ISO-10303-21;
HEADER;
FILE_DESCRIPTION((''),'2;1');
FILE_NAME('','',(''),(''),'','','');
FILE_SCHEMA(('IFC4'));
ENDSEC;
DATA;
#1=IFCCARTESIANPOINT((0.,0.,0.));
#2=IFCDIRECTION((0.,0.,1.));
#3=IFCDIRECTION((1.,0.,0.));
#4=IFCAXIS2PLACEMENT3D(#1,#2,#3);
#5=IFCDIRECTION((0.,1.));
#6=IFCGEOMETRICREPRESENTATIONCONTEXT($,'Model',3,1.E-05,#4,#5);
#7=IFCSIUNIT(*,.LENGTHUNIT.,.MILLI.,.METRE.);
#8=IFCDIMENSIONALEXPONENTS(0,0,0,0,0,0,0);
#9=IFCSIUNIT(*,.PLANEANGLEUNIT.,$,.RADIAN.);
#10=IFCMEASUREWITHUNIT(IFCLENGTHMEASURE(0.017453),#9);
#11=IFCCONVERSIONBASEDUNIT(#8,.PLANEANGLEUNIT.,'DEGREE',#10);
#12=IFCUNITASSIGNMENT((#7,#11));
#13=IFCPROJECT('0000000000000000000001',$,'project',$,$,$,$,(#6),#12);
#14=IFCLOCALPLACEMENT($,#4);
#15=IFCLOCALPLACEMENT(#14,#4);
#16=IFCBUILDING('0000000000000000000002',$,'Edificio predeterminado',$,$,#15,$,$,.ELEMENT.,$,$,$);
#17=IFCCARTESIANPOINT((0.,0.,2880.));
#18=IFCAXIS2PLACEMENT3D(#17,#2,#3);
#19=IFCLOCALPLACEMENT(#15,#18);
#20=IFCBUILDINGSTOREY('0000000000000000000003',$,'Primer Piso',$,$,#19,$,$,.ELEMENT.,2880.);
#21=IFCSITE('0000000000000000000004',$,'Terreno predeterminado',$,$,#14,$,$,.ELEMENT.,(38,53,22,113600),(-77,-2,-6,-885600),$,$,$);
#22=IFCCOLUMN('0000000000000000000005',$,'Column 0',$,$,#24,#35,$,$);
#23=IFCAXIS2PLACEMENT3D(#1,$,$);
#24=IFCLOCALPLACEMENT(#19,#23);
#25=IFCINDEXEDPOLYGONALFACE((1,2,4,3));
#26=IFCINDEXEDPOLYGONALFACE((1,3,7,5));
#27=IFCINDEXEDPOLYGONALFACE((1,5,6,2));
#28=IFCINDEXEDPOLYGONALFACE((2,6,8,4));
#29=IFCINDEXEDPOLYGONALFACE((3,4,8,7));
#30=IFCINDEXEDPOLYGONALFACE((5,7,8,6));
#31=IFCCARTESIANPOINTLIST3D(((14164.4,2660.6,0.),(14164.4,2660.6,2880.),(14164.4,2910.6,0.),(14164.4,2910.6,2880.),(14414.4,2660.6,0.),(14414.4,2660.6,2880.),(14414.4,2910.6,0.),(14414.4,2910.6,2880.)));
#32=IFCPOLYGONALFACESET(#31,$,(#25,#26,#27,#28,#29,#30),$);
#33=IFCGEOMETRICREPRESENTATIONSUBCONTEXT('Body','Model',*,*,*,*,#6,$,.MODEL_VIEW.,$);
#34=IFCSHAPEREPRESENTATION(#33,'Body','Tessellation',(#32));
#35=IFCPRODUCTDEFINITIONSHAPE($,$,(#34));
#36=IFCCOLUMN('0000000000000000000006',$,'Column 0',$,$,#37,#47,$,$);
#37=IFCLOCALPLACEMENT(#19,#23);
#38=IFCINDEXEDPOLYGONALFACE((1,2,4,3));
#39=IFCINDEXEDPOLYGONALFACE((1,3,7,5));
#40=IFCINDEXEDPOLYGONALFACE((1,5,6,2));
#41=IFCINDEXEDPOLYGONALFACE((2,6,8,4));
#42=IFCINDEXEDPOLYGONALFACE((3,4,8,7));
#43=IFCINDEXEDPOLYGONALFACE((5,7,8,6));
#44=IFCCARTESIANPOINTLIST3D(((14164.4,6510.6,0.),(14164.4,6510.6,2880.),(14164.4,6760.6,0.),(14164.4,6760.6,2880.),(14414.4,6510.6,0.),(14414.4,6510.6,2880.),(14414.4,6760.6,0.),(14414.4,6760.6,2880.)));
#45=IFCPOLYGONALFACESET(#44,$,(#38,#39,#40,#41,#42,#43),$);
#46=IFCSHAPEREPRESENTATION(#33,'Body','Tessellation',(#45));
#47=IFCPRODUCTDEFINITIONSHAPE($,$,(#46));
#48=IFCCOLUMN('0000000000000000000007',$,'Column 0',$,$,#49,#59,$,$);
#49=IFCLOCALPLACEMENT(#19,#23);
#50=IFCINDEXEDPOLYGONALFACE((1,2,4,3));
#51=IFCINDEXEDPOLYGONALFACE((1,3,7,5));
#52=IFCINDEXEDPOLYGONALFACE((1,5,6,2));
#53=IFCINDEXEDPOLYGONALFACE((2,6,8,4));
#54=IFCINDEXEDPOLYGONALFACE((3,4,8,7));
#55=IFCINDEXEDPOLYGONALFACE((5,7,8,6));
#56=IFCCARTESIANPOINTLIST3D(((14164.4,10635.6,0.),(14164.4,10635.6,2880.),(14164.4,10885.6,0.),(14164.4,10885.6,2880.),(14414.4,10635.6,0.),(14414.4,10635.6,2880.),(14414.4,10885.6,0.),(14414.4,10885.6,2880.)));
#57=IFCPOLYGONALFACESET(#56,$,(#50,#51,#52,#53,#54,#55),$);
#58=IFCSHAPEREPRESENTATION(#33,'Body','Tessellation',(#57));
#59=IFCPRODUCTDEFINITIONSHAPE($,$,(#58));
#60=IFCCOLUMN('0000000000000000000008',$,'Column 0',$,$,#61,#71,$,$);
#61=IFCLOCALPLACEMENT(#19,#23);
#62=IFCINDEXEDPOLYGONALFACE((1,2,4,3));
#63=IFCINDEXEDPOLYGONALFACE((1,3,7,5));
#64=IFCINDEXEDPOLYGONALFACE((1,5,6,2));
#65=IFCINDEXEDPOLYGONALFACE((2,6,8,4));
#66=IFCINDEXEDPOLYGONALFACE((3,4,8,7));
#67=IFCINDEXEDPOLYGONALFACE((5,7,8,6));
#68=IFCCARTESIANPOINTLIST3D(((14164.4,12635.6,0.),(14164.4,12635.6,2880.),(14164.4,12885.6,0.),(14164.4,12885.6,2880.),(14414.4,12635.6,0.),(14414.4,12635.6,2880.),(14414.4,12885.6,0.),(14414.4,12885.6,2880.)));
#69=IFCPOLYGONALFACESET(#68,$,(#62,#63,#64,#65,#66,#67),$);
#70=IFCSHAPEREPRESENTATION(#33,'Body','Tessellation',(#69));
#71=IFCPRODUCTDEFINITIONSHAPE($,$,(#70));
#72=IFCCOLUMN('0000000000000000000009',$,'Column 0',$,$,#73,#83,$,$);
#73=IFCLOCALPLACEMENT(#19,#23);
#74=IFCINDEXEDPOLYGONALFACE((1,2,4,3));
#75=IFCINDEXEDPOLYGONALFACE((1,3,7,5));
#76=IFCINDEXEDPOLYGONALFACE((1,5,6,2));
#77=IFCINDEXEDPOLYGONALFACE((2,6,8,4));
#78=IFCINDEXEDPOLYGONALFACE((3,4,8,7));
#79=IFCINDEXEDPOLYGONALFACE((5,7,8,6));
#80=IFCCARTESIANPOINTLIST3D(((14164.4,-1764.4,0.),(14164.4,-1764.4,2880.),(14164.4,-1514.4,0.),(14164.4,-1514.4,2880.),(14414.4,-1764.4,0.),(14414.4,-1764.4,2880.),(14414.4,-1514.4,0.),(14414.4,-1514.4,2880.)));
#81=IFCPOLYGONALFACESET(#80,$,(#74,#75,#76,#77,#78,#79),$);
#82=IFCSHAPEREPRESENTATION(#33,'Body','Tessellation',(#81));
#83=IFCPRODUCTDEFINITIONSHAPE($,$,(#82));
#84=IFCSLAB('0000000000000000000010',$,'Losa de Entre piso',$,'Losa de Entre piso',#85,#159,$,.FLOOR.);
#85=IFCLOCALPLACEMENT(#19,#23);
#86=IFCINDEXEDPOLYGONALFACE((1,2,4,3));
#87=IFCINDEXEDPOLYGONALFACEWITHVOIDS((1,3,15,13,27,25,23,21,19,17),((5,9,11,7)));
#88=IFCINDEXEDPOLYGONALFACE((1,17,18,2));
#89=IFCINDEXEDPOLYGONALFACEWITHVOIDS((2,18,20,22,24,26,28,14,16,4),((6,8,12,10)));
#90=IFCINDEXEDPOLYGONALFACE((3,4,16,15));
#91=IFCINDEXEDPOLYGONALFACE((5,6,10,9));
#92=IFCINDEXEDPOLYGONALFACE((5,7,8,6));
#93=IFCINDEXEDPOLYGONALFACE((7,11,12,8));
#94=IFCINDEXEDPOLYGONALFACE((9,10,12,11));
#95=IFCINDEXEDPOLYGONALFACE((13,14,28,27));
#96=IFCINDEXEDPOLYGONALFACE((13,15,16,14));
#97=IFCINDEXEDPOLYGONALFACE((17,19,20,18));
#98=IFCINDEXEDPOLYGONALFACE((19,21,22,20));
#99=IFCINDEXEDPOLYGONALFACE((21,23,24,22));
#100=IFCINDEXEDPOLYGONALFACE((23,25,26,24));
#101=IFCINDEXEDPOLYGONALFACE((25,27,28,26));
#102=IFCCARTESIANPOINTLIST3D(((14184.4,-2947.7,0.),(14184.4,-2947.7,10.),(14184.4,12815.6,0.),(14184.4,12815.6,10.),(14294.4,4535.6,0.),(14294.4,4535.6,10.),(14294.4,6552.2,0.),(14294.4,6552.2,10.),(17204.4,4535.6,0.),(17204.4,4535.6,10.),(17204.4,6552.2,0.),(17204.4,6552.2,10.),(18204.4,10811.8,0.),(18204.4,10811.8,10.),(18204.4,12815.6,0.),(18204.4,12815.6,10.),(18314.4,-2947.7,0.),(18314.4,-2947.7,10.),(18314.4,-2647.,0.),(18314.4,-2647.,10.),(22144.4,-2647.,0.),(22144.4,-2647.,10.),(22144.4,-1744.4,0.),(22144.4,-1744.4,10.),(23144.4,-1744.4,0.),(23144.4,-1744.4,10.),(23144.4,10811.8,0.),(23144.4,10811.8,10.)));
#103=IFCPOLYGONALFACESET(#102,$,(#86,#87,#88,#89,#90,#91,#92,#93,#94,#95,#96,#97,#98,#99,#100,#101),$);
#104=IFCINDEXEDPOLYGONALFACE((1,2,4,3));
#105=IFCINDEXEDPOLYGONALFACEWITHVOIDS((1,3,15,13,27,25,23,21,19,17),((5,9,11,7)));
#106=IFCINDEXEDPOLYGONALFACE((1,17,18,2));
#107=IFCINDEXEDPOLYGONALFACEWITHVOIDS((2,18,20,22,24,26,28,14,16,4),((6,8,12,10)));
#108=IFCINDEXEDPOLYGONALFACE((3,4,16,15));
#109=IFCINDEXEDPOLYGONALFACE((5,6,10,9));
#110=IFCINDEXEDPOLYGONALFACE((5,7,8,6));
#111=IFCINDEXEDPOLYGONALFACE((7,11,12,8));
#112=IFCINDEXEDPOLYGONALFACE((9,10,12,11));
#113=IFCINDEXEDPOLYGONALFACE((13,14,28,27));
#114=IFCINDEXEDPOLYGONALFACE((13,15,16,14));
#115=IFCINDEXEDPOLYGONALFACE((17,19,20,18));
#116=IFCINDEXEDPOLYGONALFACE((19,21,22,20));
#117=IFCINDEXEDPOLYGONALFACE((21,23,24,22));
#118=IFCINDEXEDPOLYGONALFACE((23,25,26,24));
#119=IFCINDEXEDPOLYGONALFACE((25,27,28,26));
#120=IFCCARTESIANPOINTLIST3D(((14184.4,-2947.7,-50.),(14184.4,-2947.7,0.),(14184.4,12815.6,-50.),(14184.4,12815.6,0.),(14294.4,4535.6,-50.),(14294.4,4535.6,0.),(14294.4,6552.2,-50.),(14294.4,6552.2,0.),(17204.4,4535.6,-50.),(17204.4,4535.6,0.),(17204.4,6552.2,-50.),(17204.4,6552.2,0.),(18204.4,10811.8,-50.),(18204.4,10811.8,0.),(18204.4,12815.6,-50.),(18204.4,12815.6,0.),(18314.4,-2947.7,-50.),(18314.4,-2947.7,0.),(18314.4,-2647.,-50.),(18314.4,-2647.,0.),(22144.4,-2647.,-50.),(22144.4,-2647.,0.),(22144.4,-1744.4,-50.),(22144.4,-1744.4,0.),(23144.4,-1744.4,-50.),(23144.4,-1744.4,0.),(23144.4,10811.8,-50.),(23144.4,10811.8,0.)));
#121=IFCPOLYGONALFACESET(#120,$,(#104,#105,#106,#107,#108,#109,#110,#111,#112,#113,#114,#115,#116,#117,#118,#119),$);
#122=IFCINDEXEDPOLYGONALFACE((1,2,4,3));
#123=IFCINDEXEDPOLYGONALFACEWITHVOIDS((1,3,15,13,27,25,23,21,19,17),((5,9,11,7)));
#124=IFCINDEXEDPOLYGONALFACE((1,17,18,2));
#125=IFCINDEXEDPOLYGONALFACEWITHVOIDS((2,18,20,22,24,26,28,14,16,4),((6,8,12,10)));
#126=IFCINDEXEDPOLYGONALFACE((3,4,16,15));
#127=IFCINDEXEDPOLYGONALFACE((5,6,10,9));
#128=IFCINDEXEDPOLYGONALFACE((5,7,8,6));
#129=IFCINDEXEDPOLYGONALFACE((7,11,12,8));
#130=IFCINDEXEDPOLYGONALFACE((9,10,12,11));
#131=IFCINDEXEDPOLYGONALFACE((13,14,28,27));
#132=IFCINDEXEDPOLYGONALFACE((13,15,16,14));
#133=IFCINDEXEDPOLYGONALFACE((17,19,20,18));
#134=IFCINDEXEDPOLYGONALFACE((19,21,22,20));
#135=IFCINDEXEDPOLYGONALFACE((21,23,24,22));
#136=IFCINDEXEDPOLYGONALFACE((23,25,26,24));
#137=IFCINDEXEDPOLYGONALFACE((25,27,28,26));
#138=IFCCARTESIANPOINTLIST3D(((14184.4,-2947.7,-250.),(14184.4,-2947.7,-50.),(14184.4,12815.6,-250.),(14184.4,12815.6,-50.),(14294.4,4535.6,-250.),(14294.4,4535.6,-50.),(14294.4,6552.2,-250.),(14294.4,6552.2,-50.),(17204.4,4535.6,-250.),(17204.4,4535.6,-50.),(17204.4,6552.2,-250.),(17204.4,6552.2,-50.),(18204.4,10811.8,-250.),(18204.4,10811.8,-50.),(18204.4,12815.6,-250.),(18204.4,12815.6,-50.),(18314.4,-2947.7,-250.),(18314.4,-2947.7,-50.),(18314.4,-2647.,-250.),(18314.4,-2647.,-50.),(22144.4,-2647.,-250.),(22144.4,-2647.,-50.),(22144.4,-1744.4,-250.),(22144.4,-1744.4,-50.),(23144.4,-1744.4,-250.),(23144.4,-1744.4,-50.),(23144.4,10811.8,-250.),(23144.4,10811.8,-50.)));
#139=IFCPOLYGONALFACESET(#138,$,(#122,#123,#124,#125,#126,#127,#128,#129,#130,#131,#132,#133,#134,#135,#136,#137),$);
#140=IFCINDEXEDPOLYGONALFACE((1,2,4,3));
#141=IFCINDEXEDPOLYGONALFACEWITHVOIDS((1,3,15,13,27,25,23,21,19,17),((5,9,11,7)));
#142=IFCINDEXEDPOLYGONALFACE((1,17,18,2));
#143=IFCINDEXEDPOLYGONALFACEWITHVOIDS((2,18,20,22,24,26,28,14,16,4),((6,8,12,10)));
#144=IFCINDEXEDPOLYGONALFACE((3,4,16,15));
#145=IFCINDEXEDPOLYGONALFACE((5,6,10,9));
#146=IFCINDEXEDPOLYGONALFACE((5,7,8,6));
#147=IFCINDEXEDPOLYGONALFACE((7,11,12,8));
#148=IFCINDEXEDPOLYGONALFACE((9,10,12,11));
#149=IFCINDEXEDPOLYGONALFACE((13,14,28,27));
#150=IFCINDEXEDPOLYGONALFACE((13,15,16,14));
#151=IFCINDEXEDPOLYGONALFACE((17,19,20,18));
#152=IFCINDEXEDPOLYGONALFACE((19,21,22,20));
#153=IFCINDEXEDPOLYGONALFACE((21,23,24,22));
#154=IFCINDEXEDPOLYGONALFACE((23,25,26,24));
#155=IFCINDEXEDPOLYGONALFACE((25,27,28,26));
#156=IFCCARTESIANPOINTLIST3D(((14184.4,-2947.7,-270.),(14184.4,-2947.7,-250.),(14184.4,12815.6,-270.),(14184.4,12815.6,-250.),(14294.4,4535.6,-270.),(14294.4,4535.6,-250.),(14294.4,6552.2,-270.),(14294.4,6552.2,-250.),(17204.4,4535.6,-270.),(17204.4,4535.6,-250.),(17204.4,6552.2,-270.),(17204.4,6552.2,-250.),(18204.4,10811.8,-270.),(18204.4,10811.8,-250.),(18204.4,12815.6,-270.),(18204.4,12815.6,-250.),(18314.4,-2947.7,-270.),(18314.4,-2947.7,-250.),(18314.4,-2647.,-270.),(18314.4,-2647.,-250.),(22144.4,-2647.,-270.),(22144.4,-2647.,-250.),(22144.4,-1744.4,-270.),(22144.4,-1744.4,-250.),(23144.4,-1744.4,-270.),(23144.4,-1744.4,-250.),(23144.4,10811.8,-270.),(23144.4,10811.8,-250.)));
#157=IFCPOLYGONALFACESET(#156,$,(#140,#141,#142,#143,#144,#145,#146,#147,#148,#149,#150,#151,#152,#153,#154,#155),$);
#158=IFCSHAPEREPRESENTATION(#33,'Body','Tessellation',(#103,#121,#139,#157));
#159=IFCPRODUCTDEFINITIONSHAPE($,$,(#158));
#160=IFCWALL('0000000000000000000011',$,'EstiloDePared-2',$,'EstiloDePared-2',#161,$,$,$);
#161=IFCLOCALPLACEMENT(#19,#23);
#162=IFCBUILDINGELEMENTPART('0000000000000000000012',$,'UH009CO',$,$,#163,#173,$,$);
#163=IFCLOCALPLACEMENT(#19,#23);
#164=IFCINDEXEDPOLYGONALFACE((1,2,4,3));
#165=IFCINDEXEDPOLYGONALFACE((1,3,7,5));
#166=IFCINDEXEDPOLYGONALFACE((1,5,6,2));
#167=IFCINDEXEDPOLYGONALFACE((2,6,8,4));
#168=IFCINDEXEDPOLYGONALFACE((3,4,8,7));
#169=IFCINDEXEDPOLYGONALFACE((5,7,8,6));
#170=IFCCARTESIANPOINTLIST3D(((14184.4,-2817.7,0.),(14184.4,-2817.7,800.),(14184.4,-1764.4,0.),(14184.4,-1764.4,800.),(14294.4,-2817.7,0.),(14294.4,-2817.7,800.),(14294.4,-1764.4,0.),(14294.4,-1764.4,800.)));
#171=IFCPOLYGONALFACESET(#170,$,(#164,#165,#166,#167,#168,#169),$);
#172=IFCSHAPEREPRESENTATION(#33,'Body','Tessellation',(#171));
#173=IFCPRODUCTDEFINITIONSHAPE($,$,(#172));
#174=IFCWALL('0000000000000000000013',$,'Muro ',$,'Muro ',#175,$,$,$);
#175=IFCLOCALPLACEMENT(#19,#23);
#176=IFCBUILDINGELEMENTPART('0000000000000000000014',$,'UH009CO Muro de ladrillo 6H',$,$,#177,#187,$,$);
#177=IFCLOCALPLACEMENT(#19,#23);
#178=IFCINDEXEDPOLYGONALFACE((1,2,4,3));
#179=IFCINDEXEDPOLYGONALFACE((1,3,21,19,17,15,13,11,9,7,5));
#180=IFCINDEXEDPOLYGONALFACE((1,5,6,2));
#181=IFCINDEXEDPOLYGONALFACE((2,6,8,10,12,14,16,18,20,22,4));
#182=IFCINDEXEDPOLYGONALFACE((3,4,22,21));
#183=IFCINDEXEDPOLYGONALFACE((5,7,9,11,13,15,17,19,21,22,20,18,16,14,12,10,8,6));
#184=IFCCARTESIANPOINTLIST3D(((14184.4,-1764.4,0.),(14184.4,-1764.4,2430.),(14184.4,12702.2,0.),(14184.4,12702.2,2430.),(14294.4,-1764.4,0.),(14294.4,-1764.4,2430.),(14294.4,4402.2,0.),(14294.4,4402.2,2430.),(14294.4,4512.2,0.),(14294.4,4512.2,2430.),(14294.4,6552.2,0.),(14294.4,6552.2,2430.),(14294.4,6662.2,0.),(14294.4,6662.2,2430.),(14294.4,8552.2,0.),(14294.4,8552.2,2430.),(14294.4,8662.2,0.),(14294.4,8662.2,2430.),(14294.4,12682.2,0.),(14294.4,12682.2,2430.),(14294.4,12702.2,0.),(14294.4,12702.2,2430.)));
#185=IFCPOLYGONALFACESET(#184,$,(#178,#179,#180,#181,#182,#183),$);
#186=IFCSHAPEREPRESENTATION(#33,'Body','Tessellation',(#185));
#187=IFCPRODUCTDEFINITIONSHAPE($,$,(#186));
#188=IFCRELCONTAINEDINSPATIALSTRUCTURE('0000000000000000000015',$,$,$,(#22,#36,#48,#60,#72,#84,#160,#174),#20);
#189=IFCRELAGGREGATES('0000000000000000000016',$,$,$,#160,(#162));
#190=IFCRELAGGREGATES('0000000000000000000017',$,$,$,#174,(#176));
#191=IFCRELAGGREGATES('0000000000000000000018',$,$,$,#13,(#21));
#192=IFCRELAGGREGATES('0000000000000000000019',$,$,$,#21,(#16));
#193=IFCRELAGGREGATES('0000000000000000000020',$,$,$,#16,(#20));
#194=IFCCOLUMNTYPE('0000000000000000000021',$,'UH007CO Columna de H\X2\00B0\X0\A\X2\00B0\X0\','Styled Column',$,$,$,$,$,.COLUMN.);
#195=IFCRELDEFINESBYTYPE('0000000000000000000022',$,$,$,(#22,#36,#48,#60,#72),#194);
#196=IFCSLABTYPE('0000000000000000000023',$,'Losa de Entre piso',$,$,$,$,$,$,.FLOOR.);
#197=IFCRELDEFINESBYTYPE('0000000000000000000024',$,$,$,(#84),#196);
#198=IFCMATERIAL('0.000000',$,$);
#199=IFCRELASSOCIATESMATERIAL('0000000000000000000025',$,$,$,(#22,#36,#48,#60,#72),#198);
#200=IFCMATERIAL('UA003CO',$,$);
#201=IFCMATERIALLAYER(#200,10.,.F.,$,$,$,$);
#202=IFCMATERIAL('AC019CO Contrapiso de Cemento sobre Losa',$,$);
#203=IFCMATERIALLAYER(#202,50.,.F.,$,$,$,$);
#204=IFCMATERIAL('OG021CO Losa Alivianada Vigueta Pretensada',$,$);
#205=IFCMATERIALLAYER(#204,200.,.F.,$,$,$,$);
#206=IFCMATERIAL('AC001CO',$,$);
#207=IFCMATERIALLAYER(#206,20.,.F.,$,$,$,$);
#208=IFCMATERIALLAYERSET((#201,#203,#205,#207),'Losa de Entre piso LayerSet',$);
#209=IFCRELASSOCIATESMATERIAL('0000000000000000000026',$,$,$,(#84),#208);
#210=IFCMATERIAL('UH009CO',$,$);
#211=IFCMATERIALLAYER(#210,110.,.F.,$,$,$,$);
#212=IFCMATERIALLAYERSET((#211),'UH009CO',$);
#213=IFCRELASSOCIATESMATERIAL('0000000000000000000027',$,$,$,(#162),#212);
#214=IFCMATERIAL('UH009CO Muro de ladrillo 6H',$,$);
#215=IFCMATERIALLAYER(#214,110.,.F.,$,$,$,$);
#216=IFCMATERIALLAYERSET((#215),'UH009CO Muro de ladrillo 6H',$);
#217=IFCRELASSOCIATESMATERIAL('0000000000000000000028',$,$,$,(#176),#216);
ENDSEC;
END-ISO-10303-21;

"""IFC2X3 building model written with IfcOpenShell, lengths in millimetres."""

from ifc_helpers import new_model, entity, si_unit, converted_unit, direction, frame, origin_with_axes, place, context, subcontext, project, spatial, polyline, outline, extrude, material, layer, layer_set, layer_usage, type_object, element, aggregate, save


model = new_model("IFC2X3")

# Units and contexts
model_context = context("Model", 3, precision=1e-05, world=origin_with_axes(), true_north=direction((0.0, 1.0)))
body_context = subcontext(model_context, "Body", "Model", "MODEL_VIEW")
ifc_project = project(units=[si_unit("LENGTHUNIT", "METRE", prefix="MILLI"), converted_unit("PLANEANGLEUNIT", "DEGREE", entity("IfcLengthMeasure", 0.017453), si_unit("PLANEANGLEUNIT", "RADIAN"), dimensions=[0, 0, 0, 0, 0, 0, 0])], contexts=[model_context])

# Site, building, storey
site_placement = place(None, origin_with_axes())
site = spatial("IfcSite", under=ifc_project, at=site_placement, Name="Terreno predeterminado", CompositionType="ELEMENT", RefLatitude=(38, 53, 22, 113600), RefLongitude=(-77, -2, -6, -885600))
building_placement = place(site_placement, origin_with_axes())
building = spatial("IfcBuilding", under=site, at=building_placement, Name="Edificio predeterminado", CompositionType="ELEMENT")
storey_placement = place(building_placement, frame((0.0, 0.0, 2880.0), z_axis=(0.0, 0.0, 1.0), x_axis=(1.0, 0.0, 0.0)))
storey = spatial("IfcBuildingStorey", under=building, at=storey_placement, Name="Primer Piso", CompositionType="ELEMENT", Elevation=2880.0)

# Columns
ifc_material_1 = material(Name="0.000000")
column_type = type_object("IfcColumnType", Name="UH007CO Columna de H°A°", Description="Styled Column", PredefinedType="COLUMN")
for number, where, z_axis, x_axis, name in (
    (1, (14289.4, 2785.6, 0.0), (0.0, 0.0, 1.0), (1.0, 0.0, 0.0), "Column 0"),
    (2, (14289.4, 6635.6, 0.0), (0.0, 0.0, 1.0), (1.0, 0.0, 0.0), "Column 0"),
    (3, (14289.4, 10760.6, 0.0), (0.0, 0.0, 1.0), (1.0, 0.0, 0.0), "Column 0"),
    (4, (14289.4, 12760.6, 0.0), (0.0, 0.0, 1.0), (1.0, 0.0, 0.0), "Column 0"),
    (5, (14289.4, -1639.4, 0.0), (0.0, 0.0, 1.0), (1.0, 0.0, 0.0), "Column 0"),
):
    element("IfcColumn", number, at=place(storey_placement, frame(where, z_axis=z_axis, x_axis=x_axis)), inside=storey, type_object=column_type, material=ifc_material_1, Name=name, context=body_context, shape_type="SweptSolid", body=[
        extrude(outline(polyline([(-125.0, -125.0), (125.0, -125.0), (125.0, 125.0), (-125.0, 125.0), (-125.0, -125.0)])), origin_with_axes(), (0.0, 0.0, 1.0), 2880.0),
    ])

# Slab
ifc_material_2 = material(Name="UA003CO")
ifc_layer_1 = layer(ifc_material_2, 10.0, ventilated=False)
ifc_material_3 = material(Name="AC019CO Contrapiso de Cemento sobre Losa")
ifc_layer_2 = layer(ifc_material_3, 50.0, ventilated=False)
ifc_material_4 = material(Name="OG021CO Losa Alivianada Vigueta Pretensada")
ifc_layer_3 = layer(ifc_material_4, 200.0, ventilated=False)
ifc_material_5 = material(Name="AC001CO")
ifc_layer_4 = layer(ifc_material_5, 20.0, ventilated=False)
ifc_layer_set_1 = layer_set([ifc_layer_1, ifc_layer_2, ifc_layer_3, ifc_layer_4], Name="Losa de Entre piso LayerSet")
ifc_layer_usage_1 = layer_usage(ifc_layer_set_1, "AXIS3", "NEGATIVE", 0.0)
slab_type = type_object("IfcSlabType", Name="Losa de Entre piso", PredefinedType="FLOOR")
slab_placement = place(storey_placement, frame((0.0, 0.0, -2880.0), z_axis=(0.0, 0.0, 1.0), x_axis=(1.0, 0.0, 0.0)))
element("IfcSlab", 6, at=slab_placement, inside=storey, type_object=slab_type, material=ifc_layer_usage_1, Name="Losa de Entre piso", ObjectType="Losa de Entre piso", PredefinedType="FLOOR", context=body_context, shape_type="SweptSolid", body=[
    extrude(outline(polyline([(0.0, 15763.4), (4130.0, 15763.4), (4130.0, 15462.6), (7960.0, 15462.6), (7960.0, 14560.0), (8960.0, 14560.0), (8960.0, 2003.8), (4020.0, 2003.8), (4020.0, 0.0), (0.0, 0.0), (0.0, 15763.4)]), holes=[polyline([(110.0, 6263.4), (3020.0, 6263.4), (3020.0, 8280.0), (110.0, 8280.0), (110.0, 6263.4)])]), frame((14184.4, 12815.6, 2880.0), z_axis=(0.0, 0.0, -1.0), x_axis=(1.0, 0.0, 0.0)), (0.0, 0.0, -1.0), 10.0),
    extrude(outline(polyline([(0.0, 15763.4), (4130.0, 15763.4), (4130.0, 15462.6), (7960.0, 15462.6), (7960.0, 14560.0), (8960.0, 14560.0), (8960.0, 2003.8), (4020.0, 2003.8), (4020.0, 0.0), (0.0, 0.0), (0.0, 15763.4)]), holes=[polyline([(110.0, 6263.4), (3020.0, 6263.4), (3020.0, 8280.0), (110.0, 8280.0), (110.0, 6263.4)])]), frame((14184.4, 12815.6, 2830.0), z_axis=(0.0, 0.0, -1.0), x_axis=(1.0, 0.0, 0.0)), (0.0, 0.0, -1.0), 50.0),
    extrude(outline(polyline([(0.0, 15763.4), (4130.0, 15763.4), (4130.0, 15462.6), (7960.0, 15462.6), (7960.0, 14560.0), (8960.0, 14560.0), (8960.0, 2003.8), (4020.0, 2003.8), (4020.0, 0.0), (0.0, 0.0), (0.0, 15763.4)]), holes=[polyline([(110.0, 6263.4), (3020.0, 6263.4), (3020.0, 8280.0), (110.0, 8280.0), (110.0, 6263.4)])]), frame((14184.4, 12815.6, 2630.0), z_axis=(0.0, 0.0, -1.0), x_axis=(1.0, 0.0, 0.0)), (0.0, 0.0, -1.0), 200.0),
    extrude(outline(polyline([(0.0, 15763.4), (4130.0, 15763.4), (4130.0, 15462.6), (7960.0, 15462.6), (7960.0, 14560.0), (8960.0, 14560.0), (8960.0, 2003.8), (4020.0, 2003.8), (4020.0, 0.0), (0.0, 0.0), (0.0, 15763.4)]), holes=[polyline([(110.0, 6263.4), (3020.0, 6263.4), (3020.0, 8280.0), (110.0, 8280.0), (110.0, 6263.4)])]), frame((14184.4, 12815.6, 2610.0), z_axis=(0.0, 0.0, -1.0), x_axis=(1.0, 0.0, 0.0)), (0.0, 0.0, -1.0), 20.0),
])

# Walls, building element parts
wall_1_placement = place(storey_placement, frame((14239.4, -2817.7, 0.0), z_axis=(0.0, 0.0, 1.0), x_axis=(0.0, 1.0, 0.0)))
wall_1 = element("IfcWall", 7, at=wall_1_placement, inside=storey, Name="EstiloDePared-2", ObjectType="EstiloDePared-2")
ifc_material_6 = material(Name="UH009CO")
ifc_layer_5 = layer(ifc_material_6, 110.0, ventilated=False)
ifc_layer_set_2 = layer_set([ifc_layer_5], Name="UH009CO")
ifc_layer_usage_2 = layer_usage(ifc_layer_set_2, "AXIS2", "NEGATIVE", -55.0)
building_element_part_1_placement = place(wall_1_placement, origin_with_axes())
building_element_part_1 = element("IfcBuildingElementPart", 8, at=building_element_part_1_placement, material=ifc_layer_usage_2, Name="UH009CO", context=body_context, shape_type="SweptSolid", body=[
    extrude(outline(polyline([(1053.4, 55.0), (1053.4, -55.0), (0.0, -55.0), (0.0, 55.0), (1053.4, 55.0)])), origin_with_axes(), (0.0, 0.0, 1.0), 800.0),
])
aggregate(wall_1, [building_element_part_1])
wall_2_placement = place(storey_placement, frame((14239.4, -1764.4, 0.0), z_axis=(0.0, 0.0, 1.0), x_axis=(0.0, 1.0, 0.0)))
wall_2 = element("IfcWall", 9, at=wall_2_placement, inside=storey, Name="Muro ", ObjectType="Muro ")
ifc_material_7 = material(Name="UH009CO Muro de ladrillo 6H")
ifc_layer_6 = layer(ifc_material_7, 110.0, ventilated=False)
ifc_layer_set_3 = layer_set([ifc_layer_6], Name="UH009CO Muro de ladrillo 6H")
ifc_layer_usage_3 = layer_usage(ifc_layer_set_3, "AXIS2", "NEGATIVE", -55.0)
building_element_part_2_placement = place(wall_2_placement, origin_with_axes())
building_element_part_2 = element("IfcBuildingElementPart", 10, at=building_element_part_2_placement, material=ifc_layer_usage_3, Name="UH009CO Muro de ladrillo 6H", context=body_context, shape_type="SweptSolid", body=[
    extrude(outline(polyline([(14466.6, 55.0), (14466.6, -55.0), (14446.6, -55.0), (10426.6, -55.0), (10316.6, -55.0), (8426.6, -55.0), (8316.6, -55.0), (6276.6, -55.0), (6166.6, -55.0), (0.0, -55.0), (0.0, 55.0), (14466.6, 55.0)])), origin_with_axes(), (0.0, 0.0, 1.0), 2430.0),
])
aggregate(wall_2, [building_element_part_2])

save(model, "model.ifc")
